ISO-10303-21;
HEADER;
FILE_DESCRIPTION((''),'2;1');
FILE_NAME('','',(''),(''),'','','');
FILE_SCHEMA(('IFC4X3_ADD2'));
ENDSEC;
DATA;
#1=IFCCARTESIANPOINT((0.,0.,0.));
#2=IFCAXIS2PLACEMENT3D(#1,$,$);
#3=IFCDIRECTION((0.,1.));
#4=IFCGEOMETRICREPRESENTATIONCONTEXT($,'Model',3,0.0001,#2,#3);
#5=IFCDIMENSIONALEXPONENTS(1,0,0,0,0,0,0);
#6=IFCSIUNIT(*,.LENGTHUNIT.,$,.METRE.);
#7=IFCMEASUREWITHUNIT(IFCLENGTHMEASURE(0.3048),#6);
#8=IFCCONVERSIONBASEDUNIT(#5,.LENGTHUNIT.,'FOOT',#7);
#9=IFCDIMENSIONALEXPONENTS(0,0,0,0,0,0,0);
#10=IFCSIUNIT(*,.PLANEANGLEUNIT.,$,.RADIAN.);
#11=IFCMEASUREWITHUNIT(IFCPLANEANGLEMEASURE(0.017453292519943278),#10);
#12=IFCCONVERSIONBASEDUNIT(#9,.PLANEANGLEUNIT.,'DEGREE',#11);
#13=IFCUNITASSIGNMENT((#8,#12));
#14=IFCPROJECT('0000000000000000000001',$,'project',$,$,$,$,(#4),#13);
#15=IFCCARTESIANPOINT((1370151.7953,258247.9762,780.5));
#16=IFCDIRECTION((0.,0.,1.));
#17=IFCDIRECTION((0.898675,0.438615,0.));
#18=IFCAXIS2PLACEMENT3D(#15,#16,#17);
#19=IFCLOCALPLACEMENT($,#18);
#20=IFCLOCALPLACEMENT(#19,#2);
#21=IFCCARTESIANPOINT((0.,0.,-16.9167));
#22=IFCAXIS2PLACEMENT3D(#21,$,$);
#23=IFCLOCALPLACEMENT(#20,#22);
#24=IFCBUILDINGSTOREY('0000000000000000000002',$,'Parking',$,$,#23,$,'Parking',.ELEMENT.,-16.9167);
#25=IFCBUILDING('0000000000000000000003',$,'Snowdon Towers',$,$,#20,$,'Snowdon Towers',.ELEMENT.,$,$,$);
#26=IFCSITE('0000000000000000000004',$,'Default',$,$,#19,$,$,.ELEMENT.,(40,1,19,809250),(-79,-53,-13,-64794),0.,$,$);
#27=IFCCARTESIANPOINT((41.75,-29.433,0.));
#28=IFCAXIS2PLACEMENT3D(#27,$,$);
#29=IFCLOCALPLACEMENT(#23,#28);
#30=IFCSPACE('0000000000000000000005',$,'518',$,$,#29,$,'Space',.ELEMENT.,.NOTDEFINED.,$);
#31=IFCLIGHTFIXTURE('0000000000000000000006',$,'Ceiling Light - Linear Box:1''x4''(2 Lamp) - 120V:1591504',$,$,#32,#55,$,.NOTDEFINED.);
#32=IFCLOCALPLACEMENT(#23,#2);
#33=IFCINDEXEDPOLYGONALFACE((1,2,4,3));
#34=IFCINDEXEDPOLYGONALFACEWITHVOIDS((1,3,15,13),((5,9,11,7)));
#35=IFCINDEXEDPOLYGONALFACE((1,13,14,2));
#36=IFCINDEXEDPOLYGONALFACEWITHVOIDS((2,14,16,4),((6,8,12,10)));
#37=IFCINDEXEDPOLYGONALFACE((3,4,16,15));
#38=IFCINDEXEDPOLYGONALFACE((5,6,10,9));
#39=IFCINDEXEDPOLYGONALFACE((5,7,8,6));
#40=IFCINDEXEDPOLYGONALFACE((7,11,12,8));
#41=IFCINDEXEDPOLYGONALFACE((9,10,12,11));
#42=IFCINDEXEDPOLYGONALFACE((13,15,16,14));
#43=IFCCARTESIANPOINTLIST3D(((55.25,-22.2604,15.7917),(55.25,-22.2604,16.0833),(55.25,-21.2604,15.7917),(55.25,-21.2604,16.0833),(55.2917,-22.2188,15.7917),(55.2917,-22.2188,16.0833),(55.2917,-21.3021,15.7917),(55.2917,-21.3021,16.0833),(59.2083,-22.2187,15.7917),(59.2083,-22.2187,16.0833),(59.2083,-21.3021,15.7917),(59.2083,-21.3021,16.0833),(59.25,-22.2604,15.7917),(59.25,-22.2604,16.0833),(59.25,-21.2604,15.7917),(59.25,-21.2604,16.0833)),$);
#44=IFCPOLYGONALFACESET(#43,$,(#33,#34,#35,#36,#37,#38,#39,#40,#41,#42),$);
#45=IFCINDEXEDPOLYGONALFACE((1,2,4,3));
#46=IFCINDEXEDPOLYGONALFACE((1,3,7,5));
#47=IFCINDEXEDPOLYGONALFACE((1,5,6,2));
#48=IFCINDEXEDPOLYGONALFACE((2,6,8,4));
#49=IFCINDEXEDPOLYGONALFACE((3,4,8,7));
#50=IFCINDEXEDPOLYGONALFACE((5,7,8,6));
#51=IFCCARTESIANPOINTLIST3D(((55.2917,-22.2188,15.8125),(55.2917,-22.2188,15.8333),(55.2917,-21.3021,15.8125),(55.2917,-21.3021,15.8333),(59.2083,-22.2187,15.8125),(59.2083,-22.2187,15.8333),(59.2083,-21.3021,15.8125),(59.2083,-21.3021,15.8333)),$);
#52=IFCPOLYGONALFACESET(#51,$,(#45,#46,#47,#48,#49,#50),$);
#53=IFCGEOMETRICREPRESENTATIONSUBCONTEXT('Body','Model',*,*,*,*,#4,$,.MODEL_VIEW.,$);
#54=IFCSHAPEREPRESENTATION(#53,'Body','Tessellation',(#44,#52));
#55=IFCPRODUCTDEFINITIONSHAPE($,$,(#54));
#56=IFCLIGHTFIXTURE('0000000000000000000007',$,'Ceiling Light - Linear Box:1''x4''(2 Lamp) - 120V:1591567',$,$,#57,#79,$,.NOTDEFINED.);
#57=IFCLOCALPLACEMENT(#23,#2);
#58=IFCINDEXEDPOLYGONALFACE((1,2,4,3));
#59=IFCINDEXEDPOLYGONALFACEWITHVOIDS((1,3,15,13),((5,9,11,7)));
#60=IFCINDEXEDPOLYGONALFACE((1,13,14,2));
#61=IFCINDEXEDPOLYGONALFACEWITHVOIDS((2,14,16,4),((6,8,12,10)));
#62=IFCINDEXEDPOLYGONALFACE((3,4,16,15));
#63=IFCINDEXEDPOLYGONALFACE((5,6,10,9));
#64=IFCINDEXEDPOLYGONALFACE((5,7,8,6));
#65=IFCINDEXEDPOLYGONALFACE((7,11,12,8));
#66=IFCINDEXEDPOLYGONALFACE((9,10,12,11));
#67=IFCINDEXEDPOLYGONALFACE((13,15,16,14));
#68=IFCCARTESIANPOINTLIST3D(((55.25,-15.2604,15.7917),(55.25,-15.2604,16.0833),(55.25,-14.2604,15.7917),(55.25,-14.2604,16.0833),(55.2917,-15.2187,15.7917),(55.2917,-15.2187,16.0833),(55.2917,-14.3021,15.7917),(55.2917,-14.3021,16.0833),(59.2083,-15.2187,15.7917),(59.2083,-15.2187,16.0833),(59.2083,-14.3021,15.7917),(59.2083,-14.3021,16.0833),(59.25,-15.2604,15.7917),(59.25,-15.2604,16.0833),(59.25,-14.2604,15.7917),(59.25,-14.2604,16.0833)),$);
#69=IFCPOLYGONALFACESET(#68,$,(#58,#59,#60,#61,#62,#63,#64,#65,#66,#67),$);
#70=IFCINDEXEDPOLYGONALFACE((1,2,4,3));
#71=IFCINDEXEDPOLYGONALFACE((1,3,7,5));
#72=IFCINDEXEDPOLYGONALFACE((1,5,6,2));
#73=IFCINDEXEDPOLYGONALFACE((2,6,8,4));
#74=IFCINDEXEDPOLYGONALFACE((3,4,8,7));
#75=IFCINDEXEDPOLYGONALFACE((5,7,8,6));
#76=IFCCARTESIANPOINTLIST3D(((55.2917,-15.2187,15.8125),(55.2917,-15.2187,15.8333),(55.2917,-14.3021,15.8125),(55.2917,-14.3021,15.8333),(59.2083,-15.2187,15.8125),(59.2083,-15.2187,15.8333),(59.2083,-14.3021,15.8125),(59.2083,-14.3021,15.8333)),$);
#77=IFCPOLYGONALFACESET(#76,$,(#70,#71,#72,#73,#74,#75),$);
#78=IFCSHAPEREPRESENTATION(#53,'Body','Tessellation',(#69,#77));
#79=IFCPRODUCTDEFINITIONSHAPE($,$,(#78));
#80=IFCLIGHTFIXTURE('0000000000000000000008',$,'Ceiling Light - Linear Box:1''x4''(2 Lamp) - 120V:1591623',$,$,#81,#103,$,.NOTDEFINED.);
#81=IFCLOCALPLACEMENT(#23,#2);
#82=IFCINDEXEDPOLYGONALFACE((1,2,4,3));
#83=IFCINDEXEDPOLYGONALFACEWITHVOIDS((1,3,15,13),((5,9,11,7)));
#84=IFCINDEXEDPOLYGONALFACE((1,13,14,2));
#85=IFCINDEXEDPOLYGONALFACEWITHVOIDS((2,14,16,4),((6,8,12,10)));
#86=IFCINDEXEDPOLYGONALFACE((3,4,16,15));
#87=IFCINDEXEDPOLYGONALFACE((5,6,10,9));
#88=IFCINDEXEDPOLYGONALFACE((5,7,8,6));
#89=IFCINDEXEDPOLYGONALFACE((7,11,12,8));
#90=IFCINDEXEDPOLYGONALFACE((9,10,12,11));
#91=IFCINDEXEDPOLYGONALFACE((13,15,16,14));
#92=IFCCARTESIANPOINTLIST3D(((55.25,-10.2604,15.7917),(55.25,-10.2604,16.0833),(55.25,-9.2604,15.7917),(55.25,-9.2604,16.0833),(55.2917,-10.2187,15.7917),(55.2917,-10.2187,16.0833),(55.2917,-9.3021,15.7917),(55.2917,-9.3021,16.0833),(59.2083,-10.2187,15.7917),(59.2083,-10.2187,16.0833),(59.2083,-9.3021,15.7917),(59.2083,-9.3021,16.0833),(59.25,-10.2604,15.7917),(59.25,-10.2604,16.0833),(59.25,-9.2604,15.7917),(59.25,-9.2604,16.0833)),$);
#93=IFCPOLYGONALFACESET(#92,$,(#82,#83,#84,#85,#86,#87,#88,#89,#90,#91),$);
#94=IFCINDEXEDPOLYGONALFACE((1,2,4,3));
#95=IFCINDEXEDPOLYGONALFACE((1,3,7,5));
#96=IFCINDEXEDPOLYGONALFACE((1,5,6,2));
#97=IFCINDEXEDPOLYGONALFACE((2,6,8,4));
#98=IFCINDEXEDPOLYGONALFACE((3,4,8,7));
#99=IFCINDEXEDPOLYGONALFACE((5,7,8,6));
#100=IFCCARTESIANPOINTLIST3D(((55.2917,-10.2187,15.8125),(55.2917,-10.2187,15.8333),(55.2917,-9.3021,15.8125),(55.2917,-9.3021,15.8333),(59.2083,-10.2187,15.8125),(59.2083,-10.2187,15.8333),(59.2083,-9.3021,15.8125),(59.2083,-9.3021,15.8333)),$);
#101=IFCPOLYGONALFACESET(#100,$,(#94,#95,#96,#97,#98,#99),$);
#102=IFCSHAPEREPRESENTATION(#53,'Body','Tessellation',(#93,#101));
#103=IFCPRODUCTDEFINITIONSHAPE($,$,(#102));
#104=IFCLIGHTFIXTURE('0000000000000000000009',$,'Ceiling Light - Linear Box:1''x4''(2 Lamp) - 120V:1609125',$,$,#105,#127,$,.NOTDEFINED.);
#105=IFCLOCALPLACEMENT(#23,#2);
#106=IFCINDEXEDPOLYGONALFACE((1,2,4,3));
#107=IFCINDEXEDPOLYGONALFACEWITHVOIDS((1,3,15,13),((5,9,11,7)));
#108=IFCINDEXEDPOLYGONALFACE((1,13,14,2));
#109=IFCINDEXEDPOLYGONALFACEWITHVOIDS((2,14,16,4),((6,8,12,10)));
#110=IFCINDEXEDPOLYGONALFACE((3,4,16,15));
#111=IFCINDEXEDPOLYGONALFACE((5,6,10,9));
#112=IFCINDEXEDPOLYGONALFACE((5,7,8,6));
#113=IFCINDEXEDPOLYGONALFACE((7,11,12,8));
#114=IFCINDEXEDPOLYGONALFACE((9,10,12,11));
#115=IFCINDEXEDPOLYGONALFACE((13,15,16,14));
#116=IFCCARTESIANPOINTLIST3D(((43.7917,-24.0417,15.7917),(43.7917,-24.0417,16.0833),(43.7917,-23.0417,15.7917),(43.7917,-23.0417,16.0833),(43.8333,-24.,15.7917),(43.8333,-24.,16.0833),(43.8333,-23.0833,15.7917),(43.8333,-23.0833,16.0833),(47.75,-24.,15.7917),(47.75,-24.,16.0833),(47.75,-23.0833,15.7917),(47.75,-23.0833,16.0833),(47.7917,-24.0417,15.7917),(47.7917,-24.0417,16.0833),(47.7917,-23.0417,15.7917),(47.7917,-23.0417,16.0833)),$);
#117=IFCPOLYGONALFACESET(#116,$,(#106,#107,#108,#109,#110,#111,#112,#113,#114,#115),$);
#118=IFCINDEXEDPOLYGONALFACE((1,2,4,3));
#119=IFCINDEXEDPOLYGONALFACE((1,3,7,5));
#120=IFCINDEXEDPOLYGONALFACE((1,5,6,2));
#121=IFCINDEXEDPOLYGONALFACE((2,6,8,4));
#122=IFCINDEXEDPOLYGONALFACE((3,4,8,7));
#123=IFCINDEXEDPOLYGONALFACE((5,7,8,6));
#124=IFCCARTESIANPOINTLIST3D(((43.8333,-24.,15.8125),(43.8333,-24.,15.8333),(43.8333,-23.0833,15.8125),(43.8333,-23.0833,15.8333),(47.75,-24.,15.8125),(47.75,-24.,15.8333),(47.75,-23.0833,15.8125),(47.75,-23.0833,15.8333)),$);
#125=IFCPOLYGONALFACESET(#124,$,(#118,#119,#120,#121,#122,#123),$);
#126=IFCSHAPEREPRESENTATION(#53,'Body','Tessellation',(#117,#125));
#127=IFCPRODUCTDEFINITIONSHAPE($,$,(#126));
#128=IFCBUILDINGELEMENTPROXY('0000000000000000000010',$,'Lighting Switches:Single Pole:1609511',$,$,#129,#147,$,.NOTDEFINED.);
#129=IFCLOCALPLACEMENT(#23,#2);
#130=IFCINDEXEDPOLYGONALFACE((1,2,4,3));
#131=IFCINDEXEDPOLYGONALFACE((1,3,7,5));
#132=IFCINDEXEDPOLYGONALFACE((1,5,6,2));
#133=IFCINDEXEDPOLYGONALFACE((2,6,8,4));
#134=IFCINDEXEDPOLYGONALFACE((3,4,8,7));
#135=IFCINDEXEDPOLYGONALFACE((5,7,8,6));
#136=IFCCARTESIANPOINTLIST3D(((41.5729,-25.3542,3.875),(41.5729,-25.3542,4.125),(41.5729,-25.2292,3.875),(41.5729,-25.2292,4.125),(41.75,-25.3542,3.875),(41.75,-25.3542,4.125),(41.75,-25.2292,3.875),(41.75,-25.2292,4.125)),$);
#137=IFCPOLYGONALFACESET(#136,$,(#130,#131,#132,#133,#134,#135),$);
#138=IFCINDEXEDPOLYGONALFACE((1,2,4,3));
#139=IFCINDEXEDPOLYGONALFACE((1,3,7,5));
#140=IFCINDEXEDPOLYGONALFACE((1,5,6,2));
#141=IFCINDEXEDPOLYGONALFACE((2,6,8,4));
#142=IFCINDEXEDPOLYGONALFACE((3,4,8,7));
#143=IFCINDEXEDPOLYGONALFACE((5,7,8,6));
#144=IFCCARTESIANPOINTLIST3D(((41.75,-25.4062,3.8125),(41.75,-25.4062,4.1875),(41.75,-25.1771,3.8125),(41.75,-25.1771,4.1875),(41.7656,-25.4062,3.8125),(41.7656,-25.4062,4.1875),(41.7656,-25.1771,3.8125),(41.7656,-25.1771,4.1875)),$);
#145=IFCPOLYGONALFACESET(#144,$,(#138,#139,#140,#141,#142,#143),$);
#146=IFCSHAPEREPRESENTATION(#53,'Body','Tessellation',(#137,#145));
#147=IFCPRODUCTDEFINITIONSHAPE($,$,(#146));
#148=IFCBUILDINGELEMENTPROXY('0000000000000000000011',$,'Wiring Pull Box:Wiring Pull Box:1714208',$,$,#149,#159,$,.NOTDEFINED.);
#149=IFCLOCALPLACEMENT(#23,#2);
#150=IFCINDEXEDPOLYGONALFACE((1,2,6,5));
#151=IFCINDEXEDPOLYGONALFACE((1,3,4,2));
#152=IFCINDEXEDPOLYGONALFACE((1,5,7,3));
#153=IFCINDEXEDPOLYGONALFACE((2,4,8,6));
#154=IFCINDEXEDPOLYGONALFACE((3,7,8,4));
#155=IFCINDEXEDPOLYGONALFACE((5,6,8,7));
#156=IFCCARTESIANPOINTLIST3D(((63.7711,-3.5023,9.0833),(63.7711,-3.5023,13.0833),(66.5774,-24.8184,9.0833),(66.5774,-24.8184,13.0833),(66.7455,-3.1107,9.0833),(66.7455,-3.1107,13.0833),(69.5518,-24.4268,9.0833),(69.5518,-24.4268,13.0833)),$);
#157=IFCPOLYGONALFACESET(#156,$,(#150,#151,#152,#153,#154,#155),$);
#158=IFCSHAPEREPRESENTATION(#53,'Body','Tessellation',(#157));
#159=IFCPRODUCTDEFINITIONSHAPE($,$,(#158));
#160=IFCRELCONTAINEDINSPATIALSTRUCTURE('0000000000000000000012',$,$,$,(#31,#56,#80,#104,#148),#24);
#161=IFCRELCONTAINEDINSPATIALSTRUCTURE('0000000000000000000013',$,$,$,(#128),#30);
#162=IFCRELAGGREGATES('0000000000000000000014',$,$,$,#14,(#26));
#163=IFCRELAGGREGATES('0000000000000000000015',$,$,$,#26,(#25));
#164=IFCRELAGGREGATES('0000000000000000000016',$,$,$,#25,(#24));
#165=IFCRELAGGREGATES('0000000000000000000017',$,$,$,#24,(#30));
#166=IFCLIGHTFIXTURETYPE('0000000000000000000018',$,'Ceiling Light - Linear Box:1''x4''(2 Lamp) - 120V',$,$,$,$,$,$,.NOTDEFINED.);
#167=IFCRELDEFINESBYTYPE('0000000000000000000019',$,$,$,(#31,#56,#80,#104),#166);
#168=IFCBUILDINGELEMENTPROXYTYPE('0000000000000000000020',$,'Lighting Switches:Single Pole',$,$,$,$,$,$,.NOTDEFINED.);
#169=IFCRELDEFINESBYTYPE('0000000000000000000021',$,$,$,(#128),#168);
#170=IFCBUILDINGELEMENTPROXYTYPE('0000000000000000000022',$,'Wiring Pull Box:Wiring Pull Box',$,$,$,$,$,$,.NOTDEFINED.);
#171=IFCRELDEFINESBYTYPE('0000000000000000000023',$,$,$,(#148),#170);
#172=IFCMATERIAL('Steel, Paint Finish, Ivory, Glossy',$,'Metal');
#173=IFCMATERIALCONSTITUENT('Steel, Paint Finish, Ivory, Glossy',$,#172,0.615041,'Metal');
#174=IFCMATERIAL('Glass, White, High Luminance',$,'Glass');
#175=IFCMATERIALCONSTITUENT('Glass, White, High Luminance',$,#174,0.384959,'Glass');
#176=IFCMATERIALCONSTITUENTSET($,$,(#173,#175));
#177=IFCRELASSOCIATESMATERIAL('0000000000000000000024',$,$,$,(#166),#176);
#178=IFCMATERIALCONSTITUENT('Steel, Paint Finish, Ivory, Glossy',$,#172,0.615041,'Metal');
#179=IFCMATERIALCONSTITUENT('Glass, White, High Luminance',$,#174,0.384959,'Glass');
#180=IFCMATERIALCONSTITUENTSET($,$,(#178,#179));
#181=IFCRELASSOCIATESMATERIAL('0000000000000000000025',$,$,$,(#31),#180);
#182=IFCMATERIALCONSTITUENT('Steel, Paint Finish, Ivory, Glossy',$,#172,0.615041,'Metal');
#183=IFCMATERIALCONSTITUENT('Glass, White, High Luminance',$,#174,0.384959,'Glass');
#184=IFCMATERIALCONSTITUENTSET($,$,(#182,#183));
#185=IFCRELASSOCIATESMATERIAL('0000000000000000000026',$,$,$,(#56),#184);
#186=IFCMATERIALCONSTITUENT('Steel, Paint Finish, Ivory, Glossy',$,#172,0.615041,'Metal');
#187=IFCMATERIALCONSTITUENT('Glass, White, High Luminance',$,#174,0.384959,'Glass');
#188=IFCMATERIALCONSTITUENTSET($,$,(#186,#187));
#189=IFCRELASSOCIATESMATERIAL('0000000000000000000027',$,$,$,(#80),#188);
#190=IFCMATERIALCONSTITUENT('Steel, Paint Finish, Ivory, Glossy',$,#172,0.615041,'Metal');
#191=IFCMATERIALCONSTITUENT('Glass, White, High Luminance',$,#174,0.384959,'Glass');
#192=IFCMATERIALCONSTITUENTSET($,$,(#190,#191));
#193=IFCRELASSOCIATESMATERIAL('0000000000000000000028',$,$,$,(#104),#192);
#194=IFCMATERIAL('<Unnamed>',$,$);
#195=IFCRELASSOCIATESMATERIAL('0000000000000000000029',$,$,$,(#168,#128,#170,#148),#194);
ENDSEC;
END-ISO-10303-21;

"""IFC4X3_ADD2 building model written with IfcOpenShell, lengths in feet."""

from ifc_helpers import new_model, entity, si_unit, converted_unit, direction, frame, frame_2d, origin, origin_2d_with_axis, place, context, subcontext, project, spatial, polyline, rectangle, outline, extrude, source, transform, mapped, material, constituent, constituent_set, type_object, type_shapes, element, save


model = new_model("IFC4X3_ADD2")

# Units and contexts
model_context = context("Model", 3, precision=0.0001, world=origin(), true_north=direction((0.0, 1.0)))
body_context = subcontext(model_context, "Body", "Model", "MODEL_VIEW")
ifc_project = project(units=[converted_unit("LENGTHUNIT", "FOOT", entity("IfcLengthMeasure", 0.3048), si_unit("LENGTHUNIT", "METRE"), dimensions=[1, 0, 0, 0, 0, 0, 0]), converted_unit("PLANEANGLEUNIT", "DEGREE", entity("IfcPlaneAngleMeasure", 0.017453292519943278), si_unit("PLANEANGLEUNIT", "RADIAN"), dimensions=[0, 0, 0, 0, 0, 0, 0])], contexts=[model_context])

# Site, building, storey
site_placement = place(None, frame((1370151.7953, 258247.9762, 780.5), z_axis=(0.0, 0.0, 1.0), x_axis=(0.898675, 0.438615, 0.0)))
site = spatial("IfcSite", under=ifc_project, at=site_placement, Name="Default", CompositionType="ELEMENT", RefLatitude=(40, 1, 19, 809250), RefLongitude=(-79, -53, -13, -64794), RefElevation=0.0)
building_placement = place(site_placement, origin())
building = spatial("IfcBuilding", under=site, at=building_placement, Name="Snowdon Towers", LongName="Snowdon Towers", CompositionType="ELEMENT")
storey_placement = place(building_placement, frame((0.0, 0.0, -16.9167)))
storey = spatial("IfcBuildingStorey", under=building, at=storey_placement, Name="Parking", LongName="Parking", CompositionType="ELEMENT", Elevation=-16.9167)

# Light fixtures
ifc_material_1 = material(Name="Steel, Paint Finish, Ivory, Glossy", Category="Metal")
ifc_constituent_1 = constituent(ifc_material_1, Name="Steel, Paint Finish, Ivory, Glossy", Category="Metal", fraction=0.615041)
ifc_material_2 = material(Name="Glass, White, High Luminance", Category="Glass")
ifc_constituent_2 = constituent(ifc_material_2, Name="Glass, White, High Luminance", Category="Glass", fraction=0.384959)
ifc_constituent_set_1 = constituent_set(constituents=[ifc_constituent_1, ifc_constituent_2])
ifc_constituent_3 = constituent(ifc_material_1, Name="Steel, Paint Finish, Ivory, Glossy", Category="Metal", fraction=0.615041)
ifc_constituent_4 = constituent(ifc_material_2, Name="Glass, White, High Luminance", Category="Glass", fraction=0.384959)
ifc_constituent_set_2 = constituent_set(constituents=[ifc_constituent_3, ifc_constituent_4])
light_fixture_type = type_object("IfcLightFixtureType", Name="Ceiling Light - Linear Box:1'x4'(2 Lamp) - 120V", PredefinedType="NOTDEFINED", material=ifc_constituent_set_2)
shared_shape_1 = source(origin(), body_context, "Body", "SweptSolid", [
    extrude(outline(polyline([(-2.0, -0.5), (2.0, -0.5), (2.0, 0.5), (-2.0, 0.5), (-2.0, -0.5)]), holes=[polyline([(-1.9583, -0.4583), (-1.9583, 0.4583), (1.9583, 0.4583), (1.9583, -0.4583), (-1.9583, -0.4583)])]), frame((0.0, -0.5, 0.0), z_axis=(0.0, 0.0, 1.0), x_axis=(-1.0, 0.0, 0.0)), (0.0, 0.0, 1.0), 0.2917),
    extrude(rectangle(XDim=3.9167, YDim=0.9167, at=origin_2d_with_axis()), frame((0.0, -0.5, 0.25), z_axis=(0.0, 0.0, 1.0), x_axis=(-1.0, 0.0, 0.0)), (0.0, 0.0, 1.0), 0.0208),
])
type_shapes(light_fixture_type, [shared_shape_1])
light_fixture_1_placement = place(storey_placement, frame((57.25, -21.2604, 16.0833), z_axis=(0.0, 0.0, -1.0), x_axis=(-1.0, 0.0, 0.0)))
element("IfcLightFixture", 1, at=light_fixture_1_placement, inside=storey, type_object=light_fixture_type, material=ifc_constituent_set_1, Name="Ceiling Light - Linear Box:1'x4'(2 Lamp) - 120V:1591504", PredefinedType="NOTDEFINED", context=body_context, shape_type="MappedRepresentation", body=[
    mapped(shared_shape_1, transform((0.0, 0.0, 0.0), scale=1.0)),
])
ifc_constituent_5 = constituent(ifc_material_1, Name="Steel, Paint Finish, Ivory, Glossy", Category="Metal", fraction=0.615041)
ifc_constituent_6 = constituent(ifc_material_2, Name="Glass, White, High Luminance", Category="Glass", fraction=0.384959)
ifc_constituent_set_3 = constituent_set(constituents=[ifc_constituent_5, ifc_constituent_6])
light_fixture_2_placement = place(storey_placement, frame((57.25, -14.2604, 16.0833), z_axis=(0.0, 0.0, -1.0), x_axis=(-1.0, 0.0, 0.0)))
element("IfcLightFixture", 2, at=light_fixture_2_placement, inside=storey, type_object=light_fixture_type, material=ifc_constituent_set_3, Name="Ceiling Light - Linear Box:1'x4'(2 Lamp) - 120V:1591567", PredefinedType="NOTDEFINED", context=body_context, shape_type="MappedRepresentation", body=[
    mapped(shared_shape_1, transform((0.0, 0.0, 0.0), scale=1.0)),
])
ifc_constituent_7 = constituent(ifc_material_1, Name="Steel, Paint Finish, Ivory, Glossy", Category="Metal", fraction=0.615041)
ifc_constituent_8 = constituent(ifc_material_2, Name="Glass, White, High Luminance", Category="Glass", fraction=0.384959)
ifc_constituent_set_4 = constituent_set(constituents=[ifc_constituent_7, ifc_constituent_8])
light_fixture_3_placement = place(storey_placement, frame((57.25, -9.2604, 16.0833), z_axis=(0.0, 0.0, -1.0), x_axis=(-1.0, 0.0, 0.0)))
element("IfcLightFixture", 3, at=light_fixture_3_placement, inside=storey, type_object=light_fixture_type, material=ifc_constituent_set_4, Name="Ceiling Light - Linear Box:1'x4'(2 Lamp) - 120V:1591623", PredefinedType="NOTDEFINED", context=body_context, shape_type="MappedRepresentation", body=[
    mapped(shared_shape_1, transform((0.0, 0.0, 0.0), scale=1.0)),
])
ifc_constituent_9 = constituent(ifc_material_1, Name="Steel, Paint Finish, Ivory, Glossy", Category="Metal", fraction=0.615041)
ifc_constituent_10 = constituent(ifc_material_2, Name="Glass, White, High Luminance", Category="Glass", fraction=0.384959)
ifc_constituent_set_5 = constituent_set(constituents=[ifc_constituent_9, ifc_constituent_10])
light_fixture_4_placement = place(storey_placement, frame((45.7917, -24.0417, 16.0833), z_axis=(0.0, 0.0, -1.0), x_axis=(1.0, 0.0, 0.0)))
element("IfcLightFixture", 4, at=light_fixture_4_placement, inside=storey, type_object=light_fixture_type, material=ifc_constituent_set_5, Name="Ceiling Light - Linear Box:1'x4'(2 Lamp) - 120V:1609125", PredefinedType="NOTDEFINED", context=body_context, shape_type="MappedRepresentation", body=[
    mapped(shared_shape_1, transform((0.0, 0.0, 0.0), scale=1.0)),
])

# Shared definitions
space_1_placement = place(storey_placement, frame((41.75, -29.433, 0.0)))
space_1 = spatial("IfcSpace", under=storey, at=space_1_placement, Name="518", LongName="Space", CompositionType="ELEMENT", PredefinedType="NOTDEFINED")

# Building element proxy
ifc_material_3 = material(Name="<Unnamed>")
building_element_proxy_type_1 = type_object("IfcBuildingElementProxyType", Name="Lighting Switches:Single Pole", PredefinedType="NOTDEFINED", material=ifc_material_3)
shared_shape_2 = source(origin(), body_context, "Body", "SweptSolid", [
    extrude(rectangle(XDim=0.125, YDim=0.25, at=origin_2d_with_axis()), frame((0.0, 0.0, -0.1771), z_axis=(0.0, 0.0, 1.0), x_axis=(-1.0, 0.0, 0.0)), (0.0, 0.0, 1.0), 0.1771),
    extrude(rectangle(XDim=0.2292, YDim=0.375, at=frame_2d((0.0, 0.0), x_axis=(1.0, 0.0))), frame((0.0, 0.0, 0.0), z_axis=(0.0, 0.0, 1.0), x_axis=(-1.0, 0.0, 0.0)), (0.0, 0.0, 1.0), 0.0156),
])
type_shapes(building_element_proxy_type_1, [shared_shape_2])
proxy_1_placement = place(space_1_placement, frame((0.0, 4.1414, 4.0), z_axis=(1.0, 0.0, 0.0), x_axis=(0.0, 1.0, 0.0)))
element("IfcBuildingElementProxy", 5, at=proxy_1_placement, inside=space_1, type_object=building_element_proxy_type_1, material=ifc_material_3, Name="Lighting Switches:Single Pole:1609511", PredefinedType="NOTDEFINED", context=body_context, shape_type="MappedRepresentation", body=[
    mapped(shared_shape_2, transform((0.0, 0.0, 0.0), scale=1.0)),
])

# Building element proxy
building_element_proxy_type_2 = type_object("IfcBuildingElementProxyType", Name="Wiring Pull Box:Wiring Pull Box", PredefinedType="NOTDEFINED", material=ifc_material_3)
shared_shape_3 = source(origin(), body_context, "Body", "SweptSolid", [
    extrude(rectangle(XDim=21.5, YDim=3.0, at=origin_2d_with_axis()), frame((0.0, 0.0, 0.0), z_axis=(0.0, 0.0, 1.0), x_axis=(-1.0, 0.0, 0.0)), (0.0, 0.0, 1.0), 4.0),
])
type_shapes(building_element_proxy_type_2, [shared_shape_3])
proxy_2_placement = place(storey_placement, frame((66.6614, -13.9645, 9.0833), z_axis=(0.0, 0.0, 1.0), x_axis=(0.130526, -0.991445, 0.0)))
element("IfcBuildingElementProxy", 6, at=proxy_2_placement, inside=storey, type_object=building_element_proxy_type_2, material=ifc_material_3, Name="Wiring Pull Box:Wiring Pull Box:1714208", PredefinedType="NOTDEFINED", context=body_context, shape_type="MappedRepresentation", body=[
    mapped(shared_shape_3, transform((0.0, 0.0, 0.0), scale=1.0)),
])

save(model, "model.ifc")
